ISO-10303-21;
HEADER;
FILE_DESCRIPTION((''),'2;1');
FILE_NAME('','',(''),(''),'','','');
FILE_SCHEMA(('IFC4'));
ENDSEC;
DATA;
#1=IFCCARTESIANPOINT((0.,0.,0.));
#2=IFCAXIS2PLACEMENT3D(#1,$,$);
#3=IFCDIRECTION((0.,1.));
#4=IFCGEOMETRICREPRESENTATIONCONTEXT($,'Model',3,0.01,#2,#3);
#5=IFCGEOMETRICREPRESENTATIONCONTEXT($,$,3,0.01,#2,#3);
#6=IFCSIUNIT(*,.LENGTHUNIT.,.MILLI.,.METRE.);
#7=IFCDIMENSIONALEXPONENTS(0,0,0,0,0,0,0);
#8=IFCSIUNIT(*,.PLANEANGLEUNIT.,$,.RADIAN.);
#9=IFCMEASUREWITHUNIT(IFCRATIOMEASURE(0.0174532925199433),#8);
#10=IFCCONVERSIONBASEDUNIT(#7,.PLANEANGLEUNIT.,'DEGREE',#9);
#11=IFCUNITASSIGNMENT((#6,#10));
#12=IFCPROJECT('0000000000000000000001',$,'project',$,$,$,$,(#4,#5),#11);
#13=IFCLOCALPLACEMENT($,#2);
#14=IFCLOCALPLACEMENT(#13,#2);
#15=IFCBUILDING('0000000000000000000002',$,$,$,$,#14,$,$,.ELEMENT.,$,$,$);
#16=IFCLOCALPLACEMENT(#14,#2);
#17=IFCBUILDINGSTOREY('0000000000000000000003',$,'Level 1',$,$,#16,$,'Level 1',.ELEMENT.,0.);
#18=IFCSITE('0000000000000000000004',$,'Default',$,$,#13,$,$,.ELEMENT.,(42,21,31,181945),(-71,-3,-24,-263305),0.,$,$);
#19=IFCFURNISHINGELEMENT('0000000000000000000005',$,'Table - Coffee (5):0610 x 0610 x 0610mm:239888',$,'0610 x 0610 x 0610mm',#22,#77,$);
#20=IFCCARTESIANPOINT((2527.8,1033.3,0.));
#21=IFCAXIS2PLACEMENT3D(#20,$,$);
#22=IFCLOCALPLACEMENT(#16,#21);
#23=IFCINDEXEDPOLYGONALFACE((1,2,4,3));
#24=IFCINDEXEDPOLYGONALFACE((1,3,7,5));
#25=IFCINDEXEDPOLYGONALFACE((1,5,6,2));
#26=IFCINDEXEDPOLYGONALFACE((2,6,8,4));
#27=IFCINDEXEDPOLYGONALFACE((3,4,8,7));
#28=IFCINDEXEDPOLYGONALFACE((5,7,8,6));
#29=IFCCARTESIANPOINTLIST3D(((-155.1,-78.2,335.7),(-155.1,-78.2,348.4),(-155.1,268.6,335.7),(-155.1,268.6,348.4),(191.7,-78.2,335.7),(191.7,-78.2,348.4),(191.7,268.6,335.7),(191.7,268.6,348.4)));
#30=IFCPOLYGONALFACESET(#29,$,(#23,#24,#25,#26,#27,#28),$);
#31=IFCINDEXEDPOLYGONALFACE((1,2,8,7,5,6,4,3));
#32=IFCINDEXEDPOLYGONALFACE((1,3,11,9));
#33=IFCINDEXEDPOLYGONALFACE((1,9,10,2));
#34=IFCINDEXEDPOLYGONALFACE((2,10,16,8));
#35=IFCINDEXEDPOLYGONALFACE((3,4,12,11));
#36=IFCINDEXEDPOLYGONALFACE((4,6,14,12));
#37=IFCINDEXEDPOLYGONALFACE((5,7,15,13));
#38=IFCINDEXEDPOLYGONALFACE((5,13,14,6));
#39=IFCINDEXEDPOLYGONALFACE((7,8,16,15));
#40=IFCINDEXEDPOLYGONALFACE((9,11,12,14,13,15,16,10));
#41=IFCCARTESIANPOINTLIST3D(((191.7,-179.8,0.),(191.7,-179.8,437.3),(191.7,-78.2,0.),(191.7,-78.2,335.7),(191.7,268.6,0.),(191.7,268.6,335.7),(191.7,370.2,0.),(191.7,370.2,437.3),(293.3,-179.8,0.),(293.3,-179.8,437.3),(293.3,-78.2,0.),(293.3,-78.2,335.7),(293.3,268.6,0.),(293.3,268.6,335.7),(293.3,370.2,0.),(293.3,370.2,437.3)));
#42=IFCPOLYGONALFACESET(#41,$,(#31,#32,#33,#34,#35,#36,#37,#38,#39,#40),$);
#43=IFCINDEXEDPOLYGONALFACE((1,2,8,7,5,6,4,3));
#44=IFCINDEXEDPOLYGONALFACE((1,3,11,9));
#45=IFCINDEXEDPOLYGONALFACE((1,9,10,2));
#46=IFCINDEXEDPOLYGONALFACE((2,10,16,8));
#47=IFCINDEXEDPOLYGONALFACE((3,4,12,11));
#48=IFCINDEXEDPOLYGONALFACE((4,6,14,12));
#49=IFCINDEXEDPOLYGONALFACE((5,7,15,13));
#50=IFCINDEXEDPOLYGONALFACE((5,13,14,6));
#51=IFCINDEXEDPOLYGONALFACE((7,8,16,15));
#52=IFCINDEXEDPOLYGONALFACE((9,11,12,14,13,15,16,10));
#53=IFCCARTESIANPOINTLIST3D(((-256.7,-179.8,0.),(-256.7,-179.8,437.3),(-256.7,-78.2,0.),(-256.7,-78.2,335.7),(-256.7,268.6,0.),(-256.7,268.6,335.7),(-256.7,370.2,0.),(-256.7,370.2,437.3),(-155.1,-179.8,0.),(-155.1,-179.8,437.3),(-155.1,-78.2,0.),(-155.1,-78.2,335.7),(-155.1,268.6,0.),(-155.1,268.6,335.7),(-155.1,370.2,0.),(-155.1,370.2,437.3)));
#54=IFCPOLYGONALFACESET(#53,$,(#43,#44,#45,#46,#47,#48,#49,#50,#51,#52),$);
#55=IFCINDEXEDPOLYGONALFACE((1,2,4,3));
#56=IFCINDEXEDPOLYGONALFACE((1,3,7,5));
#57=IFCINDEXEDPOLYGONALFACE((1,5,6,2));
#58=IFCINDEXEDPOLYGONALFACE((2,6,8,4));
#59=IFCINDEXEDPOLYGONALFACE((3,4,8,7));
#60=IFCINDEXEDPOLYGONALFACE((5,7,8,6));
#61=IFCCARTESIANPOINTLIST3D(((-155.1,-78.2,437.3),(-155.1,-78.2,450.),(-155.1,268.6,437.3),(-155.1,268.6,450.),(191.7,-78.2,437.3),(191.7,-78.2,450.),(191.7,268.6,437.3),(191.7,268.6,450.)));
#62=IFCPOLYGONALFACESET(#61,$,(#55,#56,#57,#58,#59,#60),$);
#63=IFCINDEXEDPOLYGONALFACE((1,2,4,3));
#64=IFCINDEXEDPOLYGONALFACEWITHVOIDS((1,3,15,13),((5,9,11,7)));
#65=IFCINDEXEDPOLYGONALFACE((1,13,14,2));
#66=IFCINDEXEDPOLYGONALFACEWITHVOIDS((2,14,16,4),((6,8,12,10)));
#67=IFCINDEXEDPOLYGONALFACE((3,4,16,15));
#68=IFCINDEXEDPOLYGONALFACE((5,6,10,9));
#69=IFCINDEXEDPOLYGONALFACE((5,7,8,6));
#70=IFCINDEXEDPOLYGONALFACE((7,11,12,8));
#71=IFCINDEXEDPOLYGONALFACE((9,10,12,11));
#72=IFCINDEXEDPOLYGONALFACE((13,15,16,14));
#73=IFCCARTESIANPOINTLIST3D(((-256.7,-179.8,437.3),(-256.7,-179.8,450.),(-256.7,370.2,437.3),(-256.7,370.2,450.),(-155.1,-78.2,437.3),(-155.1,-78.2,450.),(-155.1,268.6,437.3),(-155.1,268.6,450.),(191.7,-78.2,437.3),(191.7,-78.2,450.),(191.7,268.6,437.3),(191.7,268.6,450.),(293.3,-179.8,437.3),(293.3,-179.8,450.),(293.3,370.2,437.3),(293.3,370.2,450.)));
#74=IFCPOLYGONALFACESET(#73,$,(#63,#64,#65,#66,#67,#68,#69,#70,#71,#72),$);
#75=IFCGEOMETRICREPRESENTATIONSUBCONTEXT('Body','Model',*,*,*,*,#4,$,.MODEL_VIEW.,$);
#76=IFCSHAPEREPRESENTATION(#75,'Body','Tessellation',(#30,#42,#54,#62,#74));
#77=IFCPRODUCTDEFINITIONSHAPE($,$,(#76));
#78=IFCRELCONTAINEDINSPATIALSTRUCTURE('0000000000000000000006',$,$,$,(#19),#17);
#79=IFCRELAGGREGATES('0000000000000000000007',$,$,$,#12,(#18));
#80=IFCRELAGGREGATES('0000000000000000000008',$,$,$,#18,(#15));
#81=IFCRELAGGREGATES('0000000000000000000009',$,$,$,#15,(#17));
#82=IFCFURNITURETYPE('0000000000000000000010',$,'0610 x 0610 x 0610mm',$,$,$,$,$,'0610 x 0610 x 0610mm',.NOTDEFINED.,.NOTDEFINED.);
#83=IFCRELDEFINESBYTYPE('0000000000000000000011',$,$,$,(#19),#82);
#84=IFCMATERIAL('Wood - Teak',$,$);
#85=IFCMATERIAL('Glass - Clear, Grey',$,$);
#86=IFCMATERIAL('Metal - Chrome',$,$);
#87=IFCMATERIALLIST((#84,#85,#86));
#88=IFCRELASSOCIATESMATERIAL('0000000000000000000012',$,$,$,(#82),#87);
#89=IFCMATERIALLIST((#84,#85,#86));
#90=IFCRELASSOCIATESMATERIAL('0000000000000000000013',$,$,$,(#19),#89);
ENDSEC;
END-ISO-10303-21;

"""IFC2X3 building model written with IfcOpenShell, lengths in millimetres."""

from ifc_helpers import new_model, entity, si_unit, converted_unit, direction, frame, origin, origin_2d_with_axis, place, context, subcontext, project, spatial, polyline, rectangle, outline, extrude, source, transform, mapped, material, material_list, type_object, type_shapes, element, save


model = new_model("IFC2X3")

# Units and contexts
model_context = context("Model", 3, precision=0.01, world=origin(), true_north=direction((0.0, 1.0)))
context_of_model = context(None, 3, precision=0.01, world=origin(), true_north=direction((0.0, 1.0)))
body_context = subcontext(model_context, "Body", "Model", "MODEL_VIEW")
ifc_project = project(units=[si_unit("LENGTHUNIT", "METRE", prefix="MILLI"), converted_unit("PLANEANGLEUNIT", "DEGREE", entity("IfcRatioMeasure", 0.0174532925199433), si_unit("PLANEANGLEUNIT", "RADIAN"), dimensions=[0, 0, 0, 0, 0, 0, 0])], contexts=[model_context, context_of_model])

# Site, building, storey
site_placement = place(None, origin())
site = spatial("IfcSite", under=ifc_project, at=site_placement, Name="Default", CompositionType="ELEMENT", RefLatitude=(42, 21, 31, 181945), RefLongitude=(-71, -3, -24, -263305), RefElevation=0.0)
building_placement = place(site_placement, origin())
building = spatial("IfcBuilding", under=site, at=building_placement, CompositionType="ELEMENT")
storey_placement = place(building_placement, origin())
storey = spatial("IfcBuildingStorey", under=building, at=storey_placement, Name="Level 1", LongName="Level 1", CompositionType="ELEMENT", Elevation=0.0)

# Shared definitions
ifc_material_1 = material(Name="Metal - Chrome")

# Furnishing element
ifc_material_2 = material(Name="Wood - Teak")
ifc_material_3 = material(Name="Glass - Clear, Grey")
ifc_material_list_1 = material_list([ifc_material_2, ifc_material_3, ifc_material_1])
furniture_type_1 = type_object("IfcFurnitureType", Name="0610 x 0610 x 0610mm", ElementType="0610 x 0610 x 0610mm", AssemblyPlace="NOTDEFINED", material=ifc_material_list_1)
shared_shape_1 = source(origin(), body_context, "Body", "SweptSolid", [
    extrude(rectangle(XDim=346.8, YDim=346.8, at=origin_2d_with_axis()), frame((18.3, 95.2, 335.7), z_axis=(0.0, 0.0, 1.0), x_axis=(-1.0, 0.0, 0.0)), (0.0, 0.0, 1.0), 12.7),
    extrude(outline(polyline([(-193.2, -275.0), (244.0, -275.0), (244.0, 275.0), (-193.2, 275.0), (-193.2, 173.4), (142.5, 173.4), (142.5, -173.4), (-193.2, -173.4), (-193.2, -275.0)])), frame((191.7, 95.2, 193.2), z_axis=(1.0, 0.0, 0.0), x_axis=(0.0, 0.0, 1.0)), (0.0, 0.0, 1.0), 101.6),
    extrude(outline(polyline([(-275.0, -244.1), (275.0, -244.1), (275.0, 193.3), (173.4, 193.3), (173.4, -142.4), (-173.4, -142.4), (-173.4, 193.3), (-275.0, 193.3), (-275.0, -244.1)])), frame((-256.7, 95.2, 193.3), z_axis=(1.0, 0.0, 0.0), x_axis=(0.0, -1.0, 0.0)), (0.0, 0.0, 1.0), 101.6),
    extrude(rectangle(XDim=346.8, YDim=346.8, at=origin_2d_with_axis()), frame((18.3, 95.2, 437.3), z_axis=(0.0, 0.0, 1.0), x_axis=(-1.0, 0.0, 0.0)), (0.0, 0.0, 1.0), 12.7),
    extrude(outline(polyline([(-275.0, -275.0), (275.0, -275.0), (275.0, 275.0), (-275.0, 275.0), (-275.0, -275.0)]), holes=[polyline([(-173.4, -173.4), (-173.4, 173.4), (173.4, 173.4), (173.4, -173.4), (-173.4, -173.4)])]), frame((18.3, 95.2, 437.3), z_axis=(0.0, 0.0, 1.0), x_axis=(-1.0, 0.0, 0.0)), (0.0, 0.0, 1.0), 12.7),
])
type_shapes(furniture_type_1, [shared_shape_1])
ifc_material_list_2 = material_list([ifc_material_2, ifc_material_3, ifc_material_1])
furnishing_1_placement = place(storey_placement, frame((2527.8, 1033.3, 0.0)))
element("IfcFurnishingElement", 1, at=furnishing_1_placement, inside=storey, type_object=furniture_type_1, material=ifc_material_list_2, Name="Table - Coffee (5):0610 x 0610 x 0610mm:239888", ObjectType="0610 x 0610 x 0610mm", context=body_context, shape_type="MappedRepresentation", body=[
    mapped(shared_shape_1, transform((0.0, 0.0, 0.0), scale=1.0)),
])

save(model, "model.ifc")
